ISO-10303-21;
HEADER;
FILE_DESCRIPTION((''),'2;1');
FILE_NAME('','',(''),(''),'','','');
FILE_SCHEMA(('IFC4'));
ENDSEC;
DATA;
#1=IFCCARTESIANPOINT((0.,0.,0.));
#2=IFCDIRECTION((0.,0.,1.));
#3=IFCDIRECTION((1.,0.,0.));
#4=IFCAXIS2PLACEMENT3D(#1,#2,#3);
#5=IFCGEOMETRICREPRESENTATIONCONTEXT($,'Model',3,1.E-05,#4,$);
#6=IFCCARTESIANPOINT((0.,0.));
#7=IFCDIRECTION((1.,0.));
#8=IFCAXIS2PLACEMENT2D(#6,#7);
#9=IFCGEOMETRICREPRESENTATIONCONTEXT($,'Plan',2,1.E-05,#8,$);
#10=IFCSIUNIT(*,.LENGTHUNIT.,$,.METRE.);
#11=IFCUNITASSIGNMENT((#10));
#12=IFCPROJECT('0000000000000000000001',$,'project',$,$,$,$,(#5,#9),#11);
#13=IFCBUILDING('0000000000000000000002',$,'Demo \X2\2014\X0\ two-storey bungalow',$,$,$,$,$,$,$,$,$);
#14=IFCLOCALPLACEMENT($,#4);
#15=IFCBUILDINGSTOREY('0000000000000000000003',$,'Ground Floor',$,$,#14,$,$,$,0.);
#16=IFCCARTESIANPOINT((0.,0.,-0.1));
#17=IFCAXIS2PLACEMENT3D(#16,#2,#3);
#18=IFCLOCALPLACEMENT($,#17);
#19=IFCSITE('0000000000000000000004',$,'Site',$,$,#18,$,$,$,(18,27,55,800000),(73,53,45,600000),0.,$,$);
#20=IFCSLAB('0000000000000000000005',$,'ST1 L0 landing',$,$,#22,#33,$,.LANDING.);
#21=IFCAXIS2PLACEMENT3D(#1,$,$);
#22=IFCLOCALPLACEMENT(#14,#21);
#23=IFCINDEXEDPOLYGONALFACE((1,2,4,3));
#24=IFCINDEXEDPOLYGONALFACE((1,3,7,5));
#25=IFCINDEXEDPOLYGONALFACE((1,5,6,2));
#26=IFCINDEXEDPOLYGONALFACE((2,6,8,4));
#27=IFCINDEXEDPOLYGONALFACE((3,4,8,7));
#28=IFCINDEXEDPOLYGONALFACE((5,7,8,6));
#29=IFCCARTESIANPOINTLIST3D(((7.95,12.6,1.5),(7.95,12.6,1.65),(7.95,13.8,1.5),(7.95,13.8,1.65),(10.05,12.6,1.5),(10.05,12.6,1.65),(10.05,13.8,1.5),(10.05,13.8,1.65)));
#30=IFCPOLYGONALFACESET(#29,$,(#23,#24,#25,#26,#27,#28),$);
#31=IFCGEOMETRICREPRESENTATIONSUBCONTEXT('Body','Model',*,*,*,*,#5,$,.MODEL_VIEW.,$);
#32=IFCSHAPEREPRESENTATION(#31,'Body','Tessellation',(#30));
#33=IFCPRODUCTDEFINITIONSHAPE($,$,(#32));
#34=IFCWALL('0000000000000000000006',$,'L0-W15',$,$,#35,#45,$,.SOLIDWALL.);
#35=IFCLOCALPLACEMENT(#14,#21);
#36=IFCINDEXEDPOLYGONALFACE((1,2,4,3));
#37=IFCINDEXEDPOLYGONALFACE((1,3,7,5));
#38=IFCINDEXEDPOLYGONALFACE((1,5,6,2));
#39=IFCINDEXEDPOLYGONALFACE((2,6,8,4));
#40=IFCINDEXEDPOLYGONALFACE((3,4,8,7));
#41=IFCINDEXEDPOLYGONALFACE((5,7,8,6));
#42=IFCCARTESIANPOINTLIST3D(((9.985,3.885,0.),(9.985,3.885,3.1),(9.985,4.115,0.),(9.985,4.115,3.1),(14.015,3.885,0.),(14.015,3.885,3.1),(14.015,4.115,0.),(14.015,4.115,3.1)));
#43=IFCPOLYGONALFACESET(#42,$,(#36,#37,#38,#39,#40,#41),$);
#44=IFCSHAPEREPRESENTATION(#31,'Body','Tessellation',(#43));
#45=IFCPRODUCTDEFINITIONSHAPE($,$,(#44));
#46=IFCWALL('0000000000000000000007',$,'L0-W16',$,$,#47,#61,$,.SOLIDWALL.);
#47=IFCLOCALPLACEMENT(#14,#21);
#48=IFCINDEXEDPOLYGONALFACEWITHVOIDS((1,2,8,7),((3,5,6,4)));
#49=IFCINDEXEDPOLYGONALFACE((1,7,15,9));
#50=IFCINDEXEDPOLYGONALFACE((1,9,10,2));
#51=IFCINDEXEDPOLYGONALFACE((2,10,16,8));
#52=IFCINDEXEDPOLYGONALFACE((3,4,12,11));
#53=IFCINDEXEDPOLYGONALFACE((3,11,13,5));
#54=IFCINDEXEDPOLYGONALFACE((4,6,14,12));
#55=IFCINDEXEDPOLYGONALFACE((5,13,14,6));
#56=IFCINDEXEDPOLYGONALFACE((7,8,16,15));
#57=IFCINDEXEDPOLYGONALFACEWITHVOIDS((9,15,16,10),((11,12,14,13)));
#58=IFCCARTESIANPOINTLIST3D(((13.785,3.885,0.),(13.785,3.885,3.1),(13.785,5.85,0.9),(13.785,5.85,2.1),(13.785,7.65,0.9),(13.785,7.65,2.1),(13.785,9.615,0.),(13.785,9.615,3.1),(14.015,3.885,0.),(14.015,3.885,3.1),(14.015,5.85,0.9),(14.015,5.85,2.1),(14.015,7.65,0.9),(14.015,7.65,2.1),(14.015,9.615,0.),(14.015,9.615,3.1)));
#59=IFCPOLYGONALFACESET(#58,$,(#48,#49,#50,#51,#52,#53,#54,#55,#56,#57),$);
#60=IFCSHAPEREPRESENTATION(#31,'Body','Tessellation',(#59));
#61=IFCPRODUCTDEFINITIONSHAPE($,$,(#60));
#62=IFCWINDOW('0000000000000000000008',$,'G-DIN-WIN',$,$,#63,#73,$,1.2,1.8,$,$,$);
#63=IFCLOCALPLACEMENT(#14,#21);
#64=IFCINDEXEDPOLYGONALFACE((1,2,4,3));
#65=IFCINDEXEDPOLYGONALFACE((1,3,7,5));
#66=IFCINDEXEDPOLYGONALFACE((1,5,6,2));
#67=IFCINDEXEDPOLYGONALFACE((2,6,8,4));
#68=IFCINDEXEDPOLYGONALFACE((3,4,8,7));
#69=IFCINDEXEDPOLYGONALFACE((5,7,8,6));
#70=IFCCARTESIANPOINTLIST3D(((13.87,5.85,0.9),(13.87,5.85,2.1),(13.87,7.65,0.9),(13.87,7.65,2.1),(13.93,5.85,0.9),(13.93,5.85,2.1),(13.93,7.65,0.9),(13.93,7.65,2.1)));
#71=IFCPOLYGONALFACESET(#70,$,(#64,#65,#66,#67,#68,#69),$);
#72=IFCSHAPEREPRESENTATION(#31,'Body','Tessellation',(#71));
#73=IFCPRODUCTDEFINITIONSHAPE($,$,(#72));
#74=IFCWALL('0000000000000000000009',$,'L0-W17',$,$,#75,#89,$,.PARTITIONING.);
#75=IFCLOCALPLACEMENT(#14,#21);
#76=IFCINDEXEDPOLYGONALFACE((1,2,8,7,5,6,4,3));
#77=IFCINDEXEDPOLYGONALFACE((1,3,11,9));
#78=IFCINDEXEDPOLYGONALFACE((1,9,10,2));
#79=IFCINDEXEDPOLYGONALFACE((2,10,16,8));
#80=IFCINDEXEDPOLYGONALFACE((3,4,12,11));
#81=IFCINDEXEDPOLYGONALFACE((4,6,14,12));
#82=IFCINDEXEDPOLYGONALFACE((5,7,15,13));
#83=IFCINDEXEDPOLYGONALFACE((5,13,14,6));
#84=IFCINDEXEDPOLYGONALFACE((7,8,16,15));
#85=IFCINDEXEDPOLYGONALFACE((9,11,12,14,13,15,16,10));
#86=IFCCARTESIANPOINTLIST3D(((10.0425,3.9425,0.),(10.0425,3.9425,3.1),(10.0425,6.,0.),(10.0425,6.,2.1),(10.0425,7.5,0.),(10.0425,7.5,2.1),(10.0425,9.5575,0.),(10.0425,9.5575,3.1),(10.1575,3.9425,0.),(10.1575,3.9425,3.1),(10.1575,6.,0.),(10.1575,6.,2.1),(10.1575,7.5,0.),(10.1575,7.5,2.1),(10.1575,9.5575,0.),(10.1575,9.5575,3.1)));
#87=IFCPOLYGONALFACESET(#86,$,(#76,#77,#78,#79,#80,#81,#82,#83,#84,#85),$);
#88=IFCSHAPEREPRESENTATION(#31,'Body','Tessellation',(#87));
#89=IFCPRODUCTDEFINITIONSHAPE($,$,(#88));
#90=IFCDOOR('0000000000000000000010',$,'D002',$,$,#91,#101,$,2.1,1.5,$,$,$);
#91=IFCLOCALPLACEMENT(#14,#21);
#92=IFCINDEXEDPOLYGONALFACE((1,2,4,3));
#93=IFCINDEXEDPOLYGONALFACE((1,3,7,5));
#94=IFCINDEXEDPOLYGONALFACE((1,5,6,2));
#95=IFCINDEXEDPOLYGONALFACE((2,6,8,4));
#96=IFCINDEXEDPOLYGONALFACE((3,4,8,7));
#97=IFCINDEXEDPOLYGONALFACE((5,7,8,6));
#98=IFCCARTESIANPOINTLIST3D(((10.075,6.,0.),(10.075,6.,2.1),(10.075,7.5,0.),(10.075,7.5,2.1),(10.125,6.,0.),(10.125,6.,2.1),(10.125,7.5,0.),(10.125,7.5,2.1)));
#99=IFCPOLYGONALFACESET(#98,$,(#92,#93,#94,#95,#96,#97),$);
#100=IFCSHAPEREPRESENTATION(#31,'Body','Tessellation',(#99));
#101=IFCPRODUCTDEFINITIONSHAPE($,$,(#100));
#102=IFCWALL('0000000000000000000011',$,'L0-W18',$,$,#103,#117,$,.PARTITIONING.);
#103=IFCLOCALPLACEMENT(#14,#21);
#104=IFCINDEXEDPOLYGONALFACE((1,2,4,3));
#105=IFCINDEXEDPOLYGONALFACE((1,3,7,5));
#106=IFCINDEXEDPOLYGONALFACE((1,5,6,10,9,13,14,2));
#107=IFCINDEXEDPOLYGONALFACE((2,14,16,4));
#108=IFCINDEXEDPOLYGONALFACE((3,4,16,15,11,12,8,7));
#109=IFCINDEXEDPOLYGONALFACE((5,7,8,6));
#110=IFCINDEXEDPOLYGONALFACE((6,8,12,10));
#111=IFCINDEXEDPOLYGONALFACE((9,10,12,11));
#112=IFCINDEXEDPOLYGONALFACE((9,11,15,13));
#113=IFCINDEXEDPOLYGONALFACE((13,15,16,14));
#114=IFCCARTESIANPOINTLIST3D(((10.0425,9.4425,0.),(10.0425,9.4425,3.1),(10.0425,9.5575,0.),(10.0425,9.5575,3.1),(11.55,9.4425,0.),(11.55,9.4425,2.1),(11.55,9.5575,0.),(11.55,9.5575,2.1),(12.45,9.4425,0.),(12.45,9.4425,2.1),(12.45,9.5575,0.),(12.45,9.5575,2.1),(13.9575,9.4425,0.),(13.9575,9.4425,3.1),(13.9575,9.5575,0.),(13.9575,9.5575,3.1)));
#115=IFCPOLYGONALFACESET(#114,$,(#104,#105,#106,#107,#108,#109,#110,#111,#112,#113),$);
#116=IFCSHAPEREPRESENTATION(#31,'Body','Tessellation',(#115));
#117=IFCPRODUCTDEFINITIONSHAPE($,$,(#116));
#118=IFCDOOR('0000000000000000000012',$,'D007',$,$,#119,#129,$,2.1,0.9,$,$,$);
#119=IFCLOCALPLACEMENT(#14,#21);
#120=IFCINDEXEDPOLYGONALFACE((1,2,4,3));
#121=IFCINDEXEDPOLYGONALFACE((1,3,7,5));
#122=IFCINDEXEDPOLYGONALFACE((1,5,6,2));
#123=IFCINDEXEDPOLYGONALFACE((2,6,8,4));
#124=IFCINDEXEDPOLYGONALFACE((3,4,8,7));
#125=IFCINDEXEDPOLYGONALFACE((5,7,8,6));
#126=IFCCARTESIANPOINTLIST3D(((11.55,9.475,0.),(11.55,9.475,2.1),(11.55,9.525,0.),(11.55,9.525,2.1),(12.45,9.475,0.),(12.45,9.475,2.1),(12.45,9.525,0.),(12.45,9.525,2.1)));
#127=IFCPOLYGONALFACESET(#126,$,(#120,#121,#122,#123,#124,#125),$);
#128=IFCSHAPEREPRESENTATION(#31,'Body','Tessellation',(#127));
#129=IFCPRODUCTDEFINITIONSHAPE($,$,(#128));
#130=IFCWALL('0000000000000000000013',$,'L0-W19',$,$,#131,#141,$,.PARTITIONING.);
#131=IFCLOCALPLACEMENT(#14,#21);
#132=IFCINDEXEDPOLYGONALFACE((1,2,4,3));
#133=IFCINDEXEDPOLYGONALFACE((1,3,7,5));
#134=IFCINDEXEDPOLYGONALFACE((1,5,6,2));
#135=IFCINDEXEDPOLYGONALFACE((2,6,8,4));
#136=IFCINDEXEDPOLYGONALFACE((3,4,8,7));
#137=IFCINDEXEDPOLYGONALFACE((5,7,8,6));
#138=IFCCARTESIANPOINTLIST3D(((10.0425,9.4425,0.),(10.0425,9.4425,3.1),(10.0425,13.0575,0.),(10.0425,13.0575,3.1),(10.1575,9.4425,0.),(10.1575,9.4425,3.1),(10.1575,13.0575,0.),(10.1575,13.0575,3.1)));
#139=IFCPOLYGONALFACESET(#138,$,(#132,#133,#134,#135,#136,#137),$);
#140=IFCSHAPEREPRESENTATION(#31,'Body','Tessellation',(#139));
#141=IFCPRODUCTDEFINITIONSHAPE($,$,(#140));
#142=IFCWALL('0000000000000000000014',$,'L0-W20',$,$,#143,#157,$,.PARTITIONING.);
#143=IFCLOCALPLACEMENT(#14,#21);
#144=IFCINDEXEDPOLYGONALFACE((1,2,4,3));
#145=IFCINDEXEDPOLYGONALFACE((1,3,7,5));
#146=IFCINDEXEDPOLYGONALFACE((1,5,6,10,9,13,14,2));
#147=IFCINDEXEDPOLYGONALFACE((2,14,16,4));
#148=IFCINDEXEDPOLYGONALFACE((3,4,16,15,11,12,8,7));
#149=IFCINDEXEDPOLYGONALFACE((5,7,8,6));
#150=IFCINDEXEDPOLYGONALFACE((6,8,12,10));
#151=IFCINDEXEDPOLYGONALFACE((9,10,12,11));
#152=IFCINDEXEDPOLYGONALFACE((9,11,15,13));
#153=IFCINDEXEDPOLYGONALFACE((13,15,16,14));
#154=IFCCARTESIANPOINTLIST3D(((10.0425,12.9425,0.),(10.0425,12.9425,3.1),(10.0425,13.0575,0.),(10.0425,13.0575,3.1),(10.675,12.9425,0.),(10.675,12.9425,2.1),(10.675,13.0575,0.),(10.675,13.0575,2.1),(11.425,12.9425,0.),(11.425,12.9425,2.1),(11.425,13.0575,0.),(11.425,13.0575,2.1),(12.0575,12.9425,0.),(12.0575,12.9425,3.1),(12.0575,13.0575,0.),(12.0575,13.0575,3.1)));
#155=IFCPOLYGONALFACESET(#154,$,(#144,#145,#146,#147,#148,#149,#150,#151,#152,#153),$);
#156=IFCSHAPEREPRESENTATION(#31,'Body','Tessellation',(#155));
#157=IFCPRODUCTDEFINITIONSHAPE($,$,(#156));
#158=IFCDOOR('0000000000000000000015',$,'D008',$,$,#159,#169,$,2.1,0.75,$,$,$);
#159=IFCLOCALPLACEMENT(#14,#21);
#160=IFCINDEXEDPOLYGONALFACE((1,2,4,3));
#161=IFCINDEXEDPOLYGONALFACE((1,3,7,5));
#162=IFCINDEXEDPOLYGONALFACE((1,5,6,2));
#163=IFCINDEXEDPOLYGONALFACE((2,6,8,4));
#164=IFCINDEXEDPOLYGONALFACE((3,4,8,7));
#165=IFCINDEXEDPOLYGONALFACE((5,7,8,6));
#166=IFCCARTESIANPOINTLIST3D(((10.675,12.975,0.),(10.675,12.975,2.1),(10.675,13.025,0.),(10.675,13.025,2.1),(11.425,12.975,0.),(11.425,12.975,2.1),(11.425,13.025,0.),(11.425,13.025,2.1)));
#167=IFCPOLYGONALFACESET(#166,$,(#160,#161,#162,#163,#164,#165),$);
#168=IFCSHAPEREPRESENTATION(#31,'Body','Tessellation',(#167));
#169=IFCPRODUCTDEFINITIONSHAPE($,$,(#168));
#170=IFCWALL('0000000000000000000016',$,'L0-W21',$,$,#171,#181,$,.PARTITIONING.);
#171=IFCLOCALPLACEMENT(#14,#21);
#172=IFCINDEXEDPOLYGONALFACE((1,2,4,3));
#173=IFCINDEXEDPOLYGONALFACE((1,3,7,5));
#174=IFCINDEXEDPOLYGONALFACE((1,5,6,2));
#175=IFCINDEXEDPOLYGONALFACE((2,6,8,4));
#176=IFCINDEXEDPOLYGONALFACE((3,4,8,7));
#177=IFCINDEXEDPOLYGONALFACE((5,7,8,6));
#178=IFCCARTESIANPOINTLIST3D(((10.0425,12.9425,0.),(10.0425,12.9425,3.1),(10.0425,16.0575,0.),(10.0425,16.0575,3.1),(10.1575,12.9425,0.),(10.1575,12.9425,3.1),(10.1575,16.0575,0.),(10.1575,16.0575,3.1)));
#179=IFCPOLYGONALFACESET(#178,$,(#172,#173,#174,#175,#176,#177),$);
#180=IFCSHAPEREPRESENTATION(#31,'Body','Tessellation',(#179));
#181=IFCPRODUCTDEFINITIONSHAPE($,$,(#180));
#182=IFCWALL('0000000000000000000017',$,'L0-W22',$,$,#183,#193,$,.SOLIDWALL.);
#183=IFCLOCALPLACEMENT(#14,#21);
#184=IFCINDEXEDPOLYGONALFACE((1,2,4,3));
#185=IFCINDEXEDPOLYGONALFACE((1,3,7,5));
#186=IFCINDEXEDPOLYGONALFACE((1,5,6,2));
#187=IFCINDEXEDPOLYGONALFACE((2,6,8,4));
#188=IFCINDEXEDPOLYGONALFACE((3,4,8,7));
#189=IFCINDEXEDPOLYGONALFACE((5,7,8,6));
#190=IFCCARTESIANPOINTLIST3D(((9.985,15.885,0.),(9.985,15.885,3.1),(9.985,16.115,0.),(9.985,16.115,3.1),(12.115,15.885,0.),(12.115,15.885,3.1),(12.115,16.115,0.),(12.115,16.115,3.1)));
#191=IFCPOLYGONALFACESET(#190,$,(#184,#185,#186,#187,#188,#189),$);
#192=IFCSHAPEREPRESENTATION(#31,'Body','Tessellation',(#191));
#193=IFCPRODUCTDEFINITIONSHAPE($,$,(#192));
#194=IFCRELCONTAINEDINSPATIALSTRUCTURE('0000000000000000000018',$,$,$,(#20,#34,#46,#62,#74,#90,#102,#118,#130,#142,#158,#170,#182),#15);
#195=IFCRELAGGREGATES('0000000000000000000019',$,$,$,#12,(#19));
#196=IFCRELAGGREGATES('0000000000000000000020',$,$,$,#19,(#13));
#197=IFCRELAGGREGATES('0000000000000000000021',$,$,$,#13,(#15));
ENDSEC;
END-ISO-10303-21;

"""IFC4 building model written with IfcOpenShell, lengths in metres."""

from ifc_helpers import new_model, si_unit, frame, origin_with_axes, origin_2d_with_axis, place, context, subcontext, project, spatial, line, indexed_curve, outline, extrude, element, fill, save


model = new_model("IFC4")

# Units and contexts
model_context = context("Model", 3, precision=1e-05, world=origin_with_axes())
plan_context = context("Plan", 2, precision=1e-05, world=origin_2d_with_axis())
body_context = subcontext(model_context, "Body", "Model", "MODEL_VIEW")
ifc_project = project(units=[si_unit("LENGTHUNIT", "METRE")], contexts=[model_context, plan_context])

# Site, building, storey
site_placement = place(None, frame((0.0, 0.0, -0.1), z_axis=(0.0, 0.0, 1.0), x_axis=(1.0, 0.0, 0.0)))
site = spatial("IfcSite", under=ifc_project, at=site_placement, Name="Site", RefLatitude=(18, 27, 55, 800000), RefLongitude=(73, 53, 45, 600000), RefElevation=0.0)
building = spatial("IfcBuilding", under=site, Name="Demo — two-storey bungalow")
storey_placement = place(None, origin_with_axes())
storey = spatial("IfcBuildingStorey", under=building, at=storey_placement, Name="Ground Floor", Elevation=0.0)

# Slab
slab_placement = place(storey_placement, origin_with_axes())
element("IfcSlab", 1, at=slab_placement, inside=storey, Name="ST1 L0 landing", PredefinedType="LANDING", context=body_context, shape_type="SweptSolid", body=[
    extrude(outline(indexed_curve([(7.95, 12.6), (10.05, 12.6), (10.05, 13.8), (7.95, 13.8)], segments=[line(1, 2, 3, 4, 1)])), frame((0.0, 0.0, 1.5), z_axis=(0.0, 0.0, 1.0), x_axis=(1.0, 0.0, 0.0)), (0.0, 0.0, 1.0), 0.15),
])

# Wall
wall_1_placement = place(storey_placement, origin_with_axes())
element("IfcWall", 2, at=wall_1_placement, inside=storey, Name="L0-W15", PredefinedType="SOLIDWALL", context=body_context, shape_type="SweptSolid", body=[
    extrude(outline(indexed_curve([(9.985, 4.115), (14.015, 4.115), (14.015, 3.885), (9.985, 3.885)], segments=[line(1, 2, 3, 4, 1)])), origin_with_axes(), (0.0, 0.0, 1.0), 3.1),
])

# Wall, opening, window
wall_2_placement = place(storey_placement, origin_with_axes())
wall_2 = element("IfcWall", 3, at=wall_2_placement, inside=storey, Name="L0-W16", PredefinedType="SOLIDWALL", context=body_context, shape_type="SweptSolid", body=[
    extrude(outline(indexed_curve([(13.785, 3.885), (13.785, 9.615), (14.015, 9.615), (14.015, 3.885)], segments=[line(1, 2, 3, 4, 1)])), origin_with_axes(), (0.0, 0.0, 1.0), 3.1),
])
opening_1_placement = place(wall_2_placement, origin_with_axes())
opening_1 = element("IfcOpeningElement", 4, at=opening_1_placement, cuts=wall_2, context=body_context, shape_type="SweptSolid", body=[
    extrude(outline(indexed_curve([(13.735, 5.85), (13.735, 7.65), (14.065, 7.65), (14.065, 5.85)], segments=[line(1, 2, 3, 4, 1)])), frame((0.0, 0.0, 0.9), z_axis=(0.0, 0.0, 1.0), x_axis=(1.0, 0.0, 0.0)), (0.0, 0.0, 1.0), 1.2),
])
window_1_placement = place(storey_placement, origin_with_axes())
window_1 = element("IfcWindow", 5, at=window_1_placement, inside=storey, Name="G-DIN-WIN", OverallHeight=1.2, OverallWidth=1.8, context=body_context, shape_type="SweptSolid", body=[
    extrude(outline(indexed_curve([(13.87, 5.85), (13.87, 7.65), (13.93, 7.65), (13.93, 5.85)], segments=[line(1, 2, 3, 4, 1)])), frame((0.0, 0.0, 0.9), z_axis=(0.0, 0.0, 1.0), x_axis=(1.0, 0.0, 0.0)), (0.0, 0.0, 1.0), 1.2),
])
fill(opening_1, window_1)

# Walls, openings, doors
wall_3_placement = place(storey_placement, origin_with_axes())
wall_3 = element("IfcWall", 6, at=wall_3_placement, inside=storey, Name="L0-W17", PredefinedType="PARTITIONING", context=body_context, shape_type="SweptSolid", body=[
    extrude(outline(indexed_curve([(10.0425, 3.9425), (10.0425, 9.5575), (10.1575, 9.5575), (10.1575, 3.9425)], segments=[line(1, 2, 3, 4, 1)])), origin_with_axes(), (0.0, 0.0, 1.0), 3.1),
])
opening_2_placement = place(wall_3_placement, origin_with_axes())
opening_2 = element("IfcOpeningElement", 7, at=opening_2_placement, cuts=wall_3, context=body_context, shape_type="SweptSolid", body=[
    extrude(outline(indexed_curve([(9.9925, 6.0), (9.9925, 7.5), (10.2075, 7.5), (10.2075, 6.0)], segments=[line(1, 2, 3, 4, 1)])), origin_with_axes(), (0.0, 0.0, 1.0), 2.1),
])
door_1_placement = place(storey_placement, origin_with_axes())
door_1 = element("IfcDoor", 8, at=door_1_placement, inside=storey, Name="D002", OverallHeight=2.1, OverallWidth=1.5, context=body_context, shape_type="SweptSolid", body=[
    extrude(outline(indexed_curve([(10.075, 6.0), (10.075, 7.5), (10.125, 7.5), (10.125, 6.0)], segments=[line(1, 2, 3, 4, 1)])), origin_with_axes(), (0.0, 0.0, 1.0), 2.1),
])
fill(opening_2, door_1)
wall_4_placement = place(storey_placement, origin_with_axes())
wall_4 = element("IfcWall", 9, at=wall_4_placement, inside=storey, Name="L0-W18", PredefinedType="PARTITIONING", context=body_context, shape_type="SweptSolid", body=[
    extrude(outline(indexed_curve([(13.9575, 9.4425), (10.0425, 9.4425), (10.0425, 9.5575), (13.9575, 9.5575)], segments=[line(1, 2, 3, 4, 1)])), origin_with_axes(), (0.0, 0.0, 1.0), 3.1),
])
opening_3_placement = place(wall_4_placement, origin_with_axes())
opening_3 = element("IfcOpeningElement", 10, at=opening_3_placement, cuts=wall_4, context=body_context, shape_type="SweptSolid", body=[
    extrude(outline(indexed_curve([(12.45, 9.3925), (11.55, 9.3925), (11.55, 9.6075), (12.45, 9.6075)], segments=[line(1, 2, 3, 4, 1)])), origin_with_axes(), (0.0, 0.0, 1.0), 2.1),
])
door_2_placement = place(storey_placement, origin_with_axes())
door_2 = element("IfcDoor", 11, at=door_2_placement, inside=storey, Name="D007", OverallHeight=2.1, OverallWidth=0.9, context=body_context, shape_type="SweptSolid", body=[
    extrude(outline(indexed_curve([(12.45, 9.475), (11.55, 9.475), (11.55, 9.525), (12.45, 9.525)], segments=[line(1, 2, 3, 4, 1)])), origin_with_axes(), (0.0, 0.0, 1.0), 2.1),
])
fill(opening_3, door_2)

# Wall
wall_5_placement = place(storey_placement, origin_with_axes())
element("IfcWall", 12, at=wall_5_placement, inside=storey, Name="L0-W19", PredefinedType="PARTITIONING", context=body_context, shape_type="SweptSolid", body=[
    extrude(outline(indexed_curve([(10.0425, 9.4425), (10.0425, 13.0575), (10.1575, 13.0575), (10.1575, 9.4425)], segments=[line(1, 2, 3, 4, 1)])), origin_with_axes(), (0.0, 0.0, 1.0), 3.1),
])

# Wall, opening, door
wall_6_placement = place(storey_placement, origin_with_axes())
wall_6 = element("IfcWall", 13, at=wall_6_placement, inside=storey, Name="L0-W20", PredefinedType="PARTITIONING", context=body_context, shape_type="SweptSolid", body=[
    extrude(outline(indexed_curve([(12.0575, 12.9425), (10.0425, 12.9425), (10.0425, 13.0575), (12.0575, 13.0575)], segments=[line(1, 2, 3, 4, 1)])), origin_with_axes(), (0.0, 0.0, 1.0), 3.1),
])
opening_4_placement = place(wall_6_placement, origin_with_axes())
opening_4 = element("IfcOpeningElement", 14, at=opening_4_placement, cuts=wall_6, context=body_context, shape_type="SweptSolid", body=[
    extrude(outline(indexed_curve([(11.425, 12.8925), (10.675, 12.8925), (10.675, 13.1075), (11.425, 13.1075)], segments=[line(1, 2, 3, 4, 1)])), origin_with_axes(), (0.0, 0.0, 1.0), 2.1),
])
door_3_placement = place(storey_placement, origin_with_axes())
door_3 = element("IfcDoor", 15, at=door_3_placement, inside=storey, Name="D008", OverallHeight=2.1, OverallWidth=0.75, context=body_context, shape_type="SweptSolid", body=[
    extrude(outline(indexed_curve([(11.425, 12.975), (10.675, 12.975), (10.675, 13.025), (11.425, 13.025)], segments=[line(1, 2, 3, 4, 1)])), origin_with_axes(), (0.0, 0.0, 1.0), 2.1),
])
fill(opening_4, door_3)

# Walls
wall_7_placement = place(storey_placement, origin_with_axes())
element("IfcWall", 16, at=wall_7_placement, inside=storey, Name="L0-W21", PredefinedType="PARTITIONING", context=body_context, shape_type="SweptSolid", body=[
    extrude(outline(indexed_curve([(10.0425, 12.9425), (10.0425, 16.0575), (10.1575, 16.0575), (10.1575, 12.9425)], segments=[line(1, 2, 3, 4, 1)])), origin_with_axes(), (0.0, 0.0, 1.0), 3.1),
])
wall_8_placement = place(storey_placement, origin_with_axes())
element("IfcWall", 17, at=wall_8_placement, inside=storey, Name="L0-W22", PredefinedType="SOLIDWALL", context=body_context, shape_type="SweptSolid", body=[
    extrude(outline(indexed_curve([(12.115, 15.885), (9.985, 15.885), (9.985, 16.115), (12.115, 16.115)], segments=[line(1, 2, 3, 4, 1)])), origin_with_axes(), (0.0, 0.0, 1.0), 3.1),
])

save(model, "model.ifc")
